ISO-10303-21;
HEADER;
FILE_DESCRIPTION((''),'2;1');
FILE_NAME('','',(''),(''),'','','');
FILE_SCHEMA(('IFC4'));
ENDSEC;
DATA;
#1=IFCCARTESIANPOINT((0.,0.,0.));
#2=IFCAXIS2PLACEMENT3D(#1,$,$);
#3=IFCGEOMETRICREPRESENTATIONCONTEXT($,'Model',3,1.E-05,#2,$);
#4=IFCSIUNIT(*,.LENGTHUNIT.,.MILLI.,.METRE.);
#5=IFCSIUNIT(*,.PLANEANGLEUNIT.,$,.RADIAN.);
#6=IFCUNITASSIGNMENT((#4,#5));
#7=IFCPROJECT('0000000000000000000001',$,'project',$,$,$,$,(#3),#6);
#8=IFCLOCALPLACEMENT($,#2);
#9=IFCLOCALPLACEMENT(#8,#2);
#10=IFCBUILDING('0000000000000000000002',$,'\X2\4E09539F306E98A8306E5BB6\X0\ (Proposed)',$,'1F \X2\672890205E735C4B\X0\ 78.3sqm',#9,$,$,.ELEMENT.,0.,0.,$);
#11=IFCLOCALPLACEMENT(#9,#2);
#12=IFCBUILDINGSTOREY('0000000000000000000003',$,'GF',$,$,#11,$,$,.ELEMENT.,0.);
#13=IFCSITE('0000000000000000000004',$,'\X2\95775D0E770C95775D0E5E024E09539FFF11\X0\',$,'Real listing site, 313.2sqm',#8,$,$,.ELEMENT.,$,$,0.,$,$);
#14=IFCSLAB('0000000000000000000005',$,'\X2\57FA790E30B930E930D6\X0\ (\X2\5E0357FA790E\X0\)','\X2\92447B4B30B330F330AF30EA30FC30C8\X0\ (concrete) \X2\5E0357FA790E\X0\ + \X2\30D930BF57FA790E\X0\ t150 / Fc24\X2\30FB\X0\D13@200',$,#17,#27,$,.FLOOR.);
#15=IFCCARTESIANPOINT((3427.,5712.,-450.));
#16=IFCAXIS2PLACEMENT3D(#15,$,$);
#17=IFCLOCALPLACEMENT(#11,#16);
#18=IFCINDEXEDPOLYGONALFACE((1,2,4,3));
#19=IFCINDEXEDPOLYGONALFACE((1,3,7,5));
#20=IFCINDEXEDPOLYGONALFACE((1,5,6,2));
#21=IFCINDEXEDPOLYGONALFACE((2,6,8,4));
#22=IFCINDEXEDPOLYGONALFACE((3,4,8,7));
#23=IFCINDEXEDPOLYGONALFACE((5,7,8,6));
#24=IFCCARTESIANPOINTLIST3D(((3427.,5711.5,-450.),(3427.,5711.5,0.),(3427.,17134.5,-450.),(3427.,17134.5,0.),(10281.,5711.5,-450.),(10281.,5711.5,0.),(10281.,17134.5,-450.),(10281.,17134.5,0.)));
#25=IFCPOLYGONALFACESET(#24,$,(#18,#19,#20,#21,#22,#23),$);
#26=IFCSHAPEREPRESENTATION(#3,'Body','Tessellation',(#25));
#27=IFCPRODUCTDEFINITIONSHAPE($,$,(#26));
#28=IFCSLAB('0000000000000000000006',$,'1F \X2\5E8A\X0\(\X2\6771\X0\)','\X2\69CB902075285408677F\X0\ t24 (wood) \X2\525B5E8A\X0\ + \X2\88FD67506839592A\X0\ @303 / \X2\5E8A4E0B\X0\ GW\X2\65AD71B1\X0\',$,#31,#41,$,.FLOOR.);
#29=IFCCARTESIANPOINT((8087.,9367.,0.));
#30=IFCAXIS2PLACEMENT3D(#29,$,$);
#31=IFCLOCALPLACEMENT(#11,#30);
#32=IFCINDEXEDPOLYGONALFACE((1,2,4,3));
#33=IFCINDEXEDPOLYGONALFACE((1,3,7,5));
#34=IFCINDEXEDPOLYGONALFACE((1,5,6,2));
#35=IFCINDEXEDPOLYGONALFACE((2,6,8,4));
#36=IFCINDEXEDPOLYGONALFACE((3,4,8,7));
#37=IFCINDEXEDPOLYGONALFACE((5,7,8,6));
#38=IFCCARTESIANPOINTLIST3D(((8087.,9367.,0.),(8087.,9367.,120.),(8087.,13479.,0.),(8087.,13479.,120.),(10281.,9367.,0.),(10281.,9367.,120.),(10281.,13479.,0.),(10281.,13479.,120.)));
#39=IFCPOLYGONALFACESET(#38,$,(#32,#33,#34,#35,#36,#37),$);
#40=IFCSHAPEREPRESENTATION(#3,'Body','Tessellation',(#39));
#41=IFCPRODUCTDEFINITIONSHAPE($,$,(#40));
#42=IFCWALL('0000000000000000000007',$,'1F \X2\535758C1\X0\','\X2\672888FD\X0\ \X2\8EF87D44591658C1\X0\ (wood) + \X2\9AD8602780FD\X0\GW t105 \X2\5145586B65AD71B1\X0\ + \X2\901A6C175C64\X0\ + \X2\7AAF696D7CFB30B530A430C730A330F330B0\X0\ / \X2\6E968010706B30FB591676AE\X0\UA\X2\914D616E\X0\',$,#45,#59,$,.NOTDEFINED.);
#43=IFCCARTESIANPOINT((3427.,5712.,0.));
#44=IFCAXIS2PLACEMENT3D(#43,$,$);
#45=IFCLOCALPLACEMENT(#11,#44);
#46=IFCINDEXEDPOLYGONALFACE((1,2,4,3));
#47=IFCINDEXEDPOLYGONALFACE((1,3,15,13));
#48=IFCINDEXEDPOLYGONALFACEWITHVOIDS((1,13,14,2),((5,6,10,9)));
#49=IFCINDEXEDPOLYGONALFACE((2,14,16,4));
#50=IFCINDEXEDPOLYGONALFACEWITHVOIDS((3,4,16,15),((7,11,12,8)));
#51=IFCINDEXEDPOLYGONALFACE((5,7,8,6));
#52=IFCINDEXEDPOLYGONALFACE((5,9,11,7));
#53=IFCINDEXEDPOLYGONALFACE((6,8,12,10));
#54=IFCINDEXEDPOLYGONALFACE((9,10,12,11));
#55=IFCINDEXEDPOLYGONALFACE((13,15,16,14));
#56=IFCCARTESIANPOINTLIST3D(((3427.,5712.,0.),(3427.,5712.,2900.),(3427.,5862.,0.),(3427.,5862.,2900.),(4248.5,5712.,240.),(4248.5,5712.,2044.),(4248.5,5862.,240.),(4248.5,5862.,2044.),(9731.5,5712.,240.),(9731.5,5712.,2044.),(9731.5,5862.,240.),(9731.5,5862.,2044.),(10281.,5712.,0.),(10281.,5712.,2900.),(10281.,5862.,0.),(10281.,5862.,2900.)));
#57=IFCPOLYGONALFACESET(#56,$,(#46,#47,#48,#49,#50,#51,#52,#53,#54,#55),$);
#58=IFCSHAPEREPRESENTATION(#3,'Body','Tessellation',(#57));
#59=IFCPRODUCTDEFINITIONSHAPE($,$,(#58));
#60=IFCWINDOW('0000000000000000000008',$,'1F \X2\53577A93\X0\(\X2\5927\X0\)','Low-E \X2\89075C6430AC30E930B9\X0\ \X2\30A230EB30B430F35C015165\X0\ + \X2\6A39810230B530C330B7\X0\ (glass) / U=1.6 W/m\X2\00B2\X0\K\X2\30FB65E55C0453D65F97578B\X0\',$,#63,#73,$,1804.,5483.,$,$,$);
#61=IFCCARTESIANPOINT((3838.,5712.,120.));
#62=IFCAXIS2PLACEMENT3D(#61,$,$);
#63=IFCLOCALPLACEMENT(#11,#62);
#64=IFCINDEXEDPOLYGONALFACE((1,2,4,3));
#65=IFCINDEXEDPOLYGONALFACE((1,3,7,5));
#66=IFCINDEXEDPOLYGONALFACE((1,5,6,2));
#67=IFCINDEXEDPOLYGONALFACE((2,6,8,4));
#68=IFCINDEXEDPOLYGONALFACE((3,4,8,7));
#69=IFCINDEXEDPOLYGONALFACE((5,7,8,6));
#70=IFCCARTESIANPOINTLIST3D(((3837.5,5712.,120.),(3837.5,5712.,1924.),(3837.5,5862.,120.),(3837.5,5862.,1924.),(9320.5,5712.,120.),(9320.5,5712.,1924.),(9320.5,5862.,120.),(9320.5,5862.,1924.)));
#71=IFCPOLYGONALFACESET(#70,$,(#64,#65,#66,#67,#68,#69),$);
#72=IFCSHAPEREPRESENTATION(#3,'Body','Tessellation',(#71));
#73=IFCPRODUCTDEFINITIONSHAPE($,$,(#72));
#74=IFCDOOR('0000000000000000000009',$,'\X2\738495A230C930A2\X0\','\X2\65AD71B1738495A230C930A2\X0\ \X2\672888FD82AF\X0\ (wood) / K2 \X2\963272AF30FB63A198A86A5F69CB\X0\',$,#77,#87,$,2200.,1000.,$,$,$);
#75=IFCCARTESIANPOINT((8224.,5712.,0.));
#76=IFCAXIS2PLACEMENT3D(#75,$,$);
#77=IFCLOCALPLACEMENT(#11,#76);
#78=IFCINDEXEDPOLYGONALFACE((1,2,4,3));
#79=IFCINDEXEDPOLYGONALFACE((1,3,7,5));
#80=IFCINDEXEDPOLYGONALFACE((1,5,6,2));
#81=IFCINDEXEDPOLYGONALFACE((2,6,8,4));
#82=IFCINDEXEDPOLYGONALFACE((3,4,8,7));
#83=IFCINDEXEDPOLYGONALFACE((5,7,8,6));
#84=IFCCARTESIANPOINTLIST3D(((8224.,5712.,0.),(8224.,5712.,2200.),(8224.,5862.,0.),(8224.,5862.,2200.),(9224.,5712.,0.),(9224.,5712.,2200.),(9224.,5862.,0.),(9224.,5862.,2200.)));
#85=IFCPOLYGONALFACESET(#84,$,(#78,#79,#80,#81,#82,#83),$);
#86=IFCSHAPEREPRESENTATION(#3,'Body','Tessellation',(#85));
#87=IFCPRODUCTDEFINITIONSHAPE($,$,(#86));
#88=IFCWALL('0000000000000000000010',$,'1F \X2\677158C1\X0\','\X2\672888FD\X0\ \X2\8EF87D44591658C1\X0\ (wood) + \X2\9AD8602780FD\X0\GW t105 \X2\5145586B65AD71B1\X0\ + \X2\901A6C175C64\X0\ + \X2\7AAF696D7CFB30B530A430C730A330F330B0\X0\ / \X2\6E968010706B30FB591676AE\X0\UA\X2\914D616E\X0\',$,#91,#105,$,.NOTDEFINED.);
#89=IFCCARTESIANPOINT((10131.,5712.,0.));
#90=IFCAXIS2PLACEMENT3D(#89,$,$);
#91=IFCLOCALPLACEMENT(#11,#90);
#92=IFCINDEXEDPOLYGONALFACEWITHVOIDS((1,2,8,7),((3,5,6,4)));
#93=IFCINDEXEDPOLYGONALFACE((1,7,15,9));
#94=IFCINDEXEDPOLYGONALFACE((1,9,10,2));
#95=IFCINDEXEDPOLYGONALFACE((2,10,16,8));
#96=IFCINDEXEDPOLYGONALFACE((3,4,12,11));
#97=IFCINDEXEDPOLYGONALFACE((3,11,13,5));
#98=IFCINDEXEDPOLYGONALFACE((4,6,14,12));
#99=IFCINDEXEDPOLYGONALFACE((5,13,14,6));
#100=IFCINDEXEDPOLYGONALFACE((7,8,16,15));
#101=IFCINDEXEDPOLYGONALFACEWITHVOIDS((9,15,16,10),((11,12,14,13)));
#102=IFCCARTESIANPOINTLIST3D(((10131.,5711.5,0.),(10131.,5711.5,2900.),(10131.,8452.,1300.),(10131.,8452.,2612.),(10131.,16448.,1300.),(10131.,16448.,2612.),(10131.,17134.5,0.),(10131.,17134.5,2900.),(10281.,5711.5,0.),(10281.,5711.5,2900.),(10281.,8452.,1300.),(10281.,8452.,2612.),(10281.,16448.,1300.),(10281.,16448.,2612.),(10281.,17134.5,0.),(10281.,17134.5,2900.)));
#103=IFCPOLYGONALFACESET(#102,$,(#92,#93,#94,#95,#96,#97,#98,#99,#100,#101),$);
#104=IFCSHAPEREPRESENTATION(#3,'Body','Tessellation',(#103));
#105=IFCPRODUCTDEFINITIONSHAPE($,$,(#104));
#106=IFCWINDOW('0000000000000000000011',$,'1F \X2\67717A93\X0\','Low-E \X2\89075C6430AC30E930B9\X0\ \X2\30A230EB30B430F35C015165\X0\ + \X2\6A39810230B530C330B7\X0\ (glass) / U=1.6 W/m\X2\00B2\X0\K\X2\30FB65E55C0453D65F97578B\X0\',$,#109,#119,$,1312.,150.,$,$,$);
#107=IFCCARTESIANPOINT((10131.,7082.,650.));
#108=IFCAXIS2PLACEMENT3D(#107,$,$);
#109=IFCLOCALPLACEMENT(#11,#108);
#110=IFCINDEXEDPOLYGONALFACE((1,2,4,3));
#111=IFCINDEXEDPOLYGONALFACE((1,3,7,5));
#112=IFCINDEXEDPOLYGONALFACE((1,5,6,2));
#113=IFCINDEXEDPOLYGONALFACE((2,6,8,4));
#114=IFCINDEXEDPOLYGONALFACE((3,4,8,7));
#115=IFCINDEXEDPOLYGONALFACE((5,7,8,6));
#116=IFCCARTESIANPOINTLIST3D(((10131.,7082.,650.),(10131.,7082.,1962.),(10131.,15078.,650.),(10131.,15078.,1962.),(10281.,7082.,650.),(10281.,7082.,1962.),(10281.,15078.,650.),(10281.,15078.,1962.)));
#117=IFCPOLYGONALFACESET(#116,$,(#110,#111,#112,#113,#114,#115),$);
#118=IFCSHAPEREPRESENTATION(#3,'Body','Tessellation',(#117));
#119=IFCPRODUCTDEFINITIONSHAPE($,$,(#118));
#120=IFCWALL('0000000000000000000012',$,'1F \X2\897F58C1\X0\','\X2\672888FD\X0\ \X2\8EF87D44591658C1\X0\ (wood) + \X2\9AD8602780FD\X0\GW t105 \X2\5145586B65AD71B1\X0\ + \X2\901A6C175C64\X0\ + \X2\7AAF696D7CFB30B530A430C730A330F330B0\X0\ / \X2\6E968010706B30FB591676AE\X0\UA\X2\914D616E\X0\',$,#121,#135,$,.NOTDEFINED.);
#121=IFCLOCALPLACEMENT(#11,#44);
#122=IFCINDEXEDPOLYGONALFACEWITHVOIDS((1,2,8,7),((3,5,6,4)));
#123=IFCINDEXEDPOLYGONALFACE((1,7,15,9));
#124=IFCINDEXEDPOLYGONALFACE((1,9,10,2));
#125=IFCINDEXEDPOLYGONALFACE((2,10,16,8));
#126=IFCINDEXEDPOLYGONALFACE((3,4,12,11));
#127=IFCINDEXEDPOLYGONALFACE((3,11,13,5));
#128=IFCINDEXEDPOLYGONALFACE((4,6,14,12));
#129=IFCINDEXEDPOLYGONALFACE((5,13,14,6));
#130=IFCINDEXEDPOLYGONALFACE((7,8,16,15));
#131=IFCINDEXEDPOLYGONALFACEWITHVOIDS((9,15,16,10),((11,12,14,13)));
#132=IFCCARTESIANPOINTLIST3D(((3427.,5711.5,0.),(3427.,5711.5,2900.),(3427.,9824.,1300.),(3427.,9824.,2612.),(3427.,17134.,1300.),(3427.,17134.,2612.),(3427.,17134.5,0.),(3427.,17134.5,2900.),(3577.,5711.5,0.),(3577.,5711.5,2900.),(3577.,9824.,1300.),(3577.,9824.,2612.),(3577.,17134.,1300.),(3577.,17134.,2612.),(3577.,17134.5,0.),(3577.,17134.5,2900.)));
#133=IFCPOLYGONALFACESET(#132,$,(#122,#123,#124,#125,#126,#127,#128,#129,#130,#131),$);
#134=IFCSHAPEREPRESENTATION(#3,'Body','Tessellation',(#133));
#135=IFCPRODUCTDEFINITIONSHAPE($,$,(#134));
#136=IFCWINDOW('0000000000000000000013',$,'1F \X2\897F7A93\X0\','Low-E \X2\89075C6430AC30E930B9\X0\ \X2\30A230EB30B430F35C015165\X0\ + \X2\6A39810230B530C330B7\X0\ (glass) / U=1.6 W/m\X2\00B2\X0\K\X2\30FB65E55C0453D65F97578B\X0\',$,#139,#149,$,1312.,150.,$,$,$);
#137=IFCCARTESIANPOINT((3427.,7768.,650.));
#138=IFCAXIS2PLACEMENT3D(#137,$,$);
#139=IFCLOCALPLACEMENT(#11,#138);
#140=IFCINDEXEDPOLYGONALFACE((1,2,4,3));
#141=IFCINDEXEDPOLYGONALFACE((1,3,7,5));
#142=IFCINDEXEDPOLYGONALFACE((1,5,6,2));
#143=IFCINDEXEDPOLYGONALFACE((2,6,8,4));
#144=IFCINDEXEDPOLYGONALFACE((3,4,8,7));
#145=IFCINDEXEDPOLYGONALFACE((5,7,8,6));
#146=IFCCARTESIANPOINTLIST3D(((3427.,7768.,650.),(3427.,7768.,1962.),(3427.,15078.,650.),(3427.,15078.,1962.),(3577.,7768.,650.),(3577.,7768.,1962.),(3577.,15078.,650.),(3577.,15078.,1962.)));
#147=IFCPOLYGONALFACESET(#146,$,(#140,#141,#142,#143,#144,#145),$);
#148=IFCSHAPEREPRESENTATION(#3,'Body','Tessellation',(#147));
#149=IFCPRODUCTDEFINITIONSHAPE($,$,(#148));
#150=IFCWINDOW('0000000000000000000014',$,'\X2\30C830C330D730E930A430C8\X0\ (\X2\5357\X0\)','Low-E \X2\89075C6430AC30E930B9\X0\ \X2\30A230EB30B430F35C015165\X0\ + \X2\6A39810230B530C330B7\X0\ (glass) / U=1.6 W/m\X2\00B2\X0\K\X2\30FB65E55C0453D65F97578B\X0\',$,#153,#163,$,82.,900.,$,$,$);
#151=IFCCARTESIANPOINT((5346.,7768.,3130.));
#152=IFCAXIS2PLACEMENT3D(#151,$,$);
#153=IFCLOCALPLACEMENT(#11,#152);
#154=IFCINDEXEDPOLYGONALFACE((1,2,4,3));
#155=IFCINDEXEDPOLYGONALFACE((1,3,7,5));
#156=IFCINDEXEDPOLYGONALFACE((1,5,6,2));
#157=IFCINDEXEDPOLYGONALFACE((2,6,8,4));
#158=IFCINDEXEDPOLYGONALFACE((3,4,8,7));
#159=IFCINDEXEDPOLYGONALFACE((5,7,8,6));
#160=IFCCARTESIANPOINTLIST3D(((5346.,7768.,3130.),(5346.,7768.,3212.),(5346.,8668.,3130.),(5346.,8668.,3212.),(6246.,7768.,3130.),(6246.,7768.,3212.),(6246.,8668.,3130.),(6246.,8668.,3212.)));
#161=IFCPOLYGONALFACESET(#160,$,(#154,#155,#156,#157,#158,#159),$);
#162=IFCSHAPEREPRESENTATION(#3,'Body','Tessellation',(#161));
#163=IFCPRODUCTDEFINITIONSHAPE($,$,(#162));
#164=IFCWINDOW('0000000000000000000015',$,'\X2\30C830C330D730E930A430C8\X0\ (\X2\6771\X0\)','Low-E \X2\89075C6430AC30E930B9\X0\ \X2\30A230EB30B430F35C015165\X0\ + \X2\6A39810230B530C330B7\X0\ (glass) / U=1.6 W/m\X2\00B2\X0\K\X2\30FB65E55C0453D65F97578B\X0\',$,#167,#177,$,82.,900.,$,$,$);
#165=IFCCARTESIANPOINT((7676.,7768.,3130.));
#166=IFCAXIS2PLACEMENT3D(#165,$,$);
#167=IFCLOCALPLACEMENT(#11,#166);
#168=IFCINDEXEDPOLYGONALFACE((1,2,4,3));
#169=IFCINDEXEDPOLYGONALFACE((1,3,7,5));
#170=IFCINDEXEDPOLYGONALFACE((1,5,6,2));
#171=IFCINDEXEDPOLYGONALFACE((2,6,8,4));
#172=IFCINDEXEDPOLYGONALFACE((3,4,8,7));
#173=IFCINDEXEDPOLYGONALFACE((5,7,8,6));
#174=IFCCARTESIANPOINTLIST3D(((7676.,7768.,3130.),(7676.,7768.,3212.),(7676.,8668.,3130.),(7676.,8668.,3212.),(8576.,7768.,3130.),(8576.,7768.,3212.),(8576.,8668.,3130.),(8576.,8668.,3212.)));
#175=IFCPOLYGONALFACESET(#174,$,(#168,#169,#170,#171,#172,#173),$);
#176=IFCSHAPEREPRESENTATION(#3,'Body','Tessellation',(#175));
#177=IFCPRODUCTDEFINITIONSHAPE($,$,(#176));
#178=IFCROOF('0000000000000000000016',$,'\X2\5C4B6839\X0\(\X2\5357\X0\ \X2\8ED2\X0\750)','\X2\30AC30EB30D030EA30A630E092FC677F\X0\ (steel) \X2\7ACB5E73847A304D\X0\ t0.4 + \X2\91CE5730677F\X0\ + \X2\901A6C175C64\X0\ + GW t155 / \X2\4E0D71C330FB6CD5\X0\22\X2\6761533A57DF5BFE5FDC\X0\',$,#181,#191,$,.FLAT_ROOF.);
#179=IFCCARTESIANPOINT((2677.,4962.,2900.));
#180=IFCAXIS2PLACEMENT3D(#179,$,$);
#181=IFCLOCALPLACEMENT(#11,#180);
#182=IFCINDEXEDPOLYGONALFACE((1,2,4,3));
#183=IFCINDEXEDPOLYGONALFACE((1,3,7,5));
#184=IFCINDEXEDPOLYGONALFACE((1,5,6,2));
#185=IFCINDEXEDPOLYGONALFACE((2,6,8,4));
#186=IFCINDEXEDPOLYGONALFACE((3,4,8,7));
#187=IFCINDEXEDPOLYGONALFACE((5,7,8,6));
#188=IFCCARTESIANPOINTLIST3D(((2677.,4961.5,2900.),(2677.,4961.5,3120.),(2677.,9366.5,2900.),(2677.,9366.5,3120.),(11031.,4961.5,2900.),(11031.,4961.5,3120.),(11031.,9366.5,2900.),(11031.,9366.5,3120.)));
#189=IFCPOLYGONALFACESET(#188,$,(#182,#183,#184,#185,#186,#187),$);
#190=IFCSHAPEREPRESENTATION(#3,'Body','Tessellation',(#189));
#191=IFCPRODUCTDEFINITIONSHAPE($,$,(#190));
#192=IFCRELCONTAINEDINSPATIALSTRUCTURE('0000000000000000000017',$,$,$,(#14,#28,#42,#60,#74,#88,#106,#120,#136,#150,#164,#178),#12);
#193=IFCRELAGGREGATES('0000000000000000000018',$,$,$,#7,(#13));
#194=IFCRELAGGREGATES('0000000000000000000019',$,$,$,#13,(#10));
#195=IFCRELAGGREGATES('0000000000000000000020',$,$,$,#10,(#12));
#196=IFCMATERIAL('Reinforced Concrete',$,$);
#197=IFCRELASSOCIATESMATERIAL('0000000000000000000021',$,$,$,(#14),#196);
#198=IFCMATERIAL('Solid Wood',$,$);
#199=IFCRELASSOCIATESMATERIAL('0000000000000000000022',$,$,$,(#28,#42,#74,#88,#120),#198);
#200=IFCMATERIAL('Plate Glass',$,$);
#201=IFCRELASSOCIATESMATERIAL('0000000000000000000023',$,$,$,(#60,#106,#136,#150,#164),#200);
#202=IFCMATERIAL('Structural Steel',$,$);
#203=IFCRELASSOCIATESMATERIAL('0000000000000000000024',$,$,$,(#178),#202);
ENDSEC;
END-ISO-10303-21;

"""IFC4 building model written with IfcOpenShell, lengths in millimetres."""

from ifc_helpers import new_model, si_unit, frame, frame_2d, origin, place, context, project, spatial, rectangle, extrude, material, element, fill, save


model = new_model("IFC4")

# Units and contexts
model_context = context("Model", 3, precision=1e-05, world=origin())
ifc_project = project(units=[si_unit("LENGTHUNIT", "METRE", prefix="MILLI"), si_unit("PLANEANGLEUNIT", "RADIAN")], contexts=[model_context])

# Site, building, storey
site_placement = place(None, origin())
site = spatial("IfcSite", under=ifc_project, at=site_placement, Name="長崎県長崎市三原１", ObjectType="Real listing site, 313.2sqm", CompositionType="ELEMENT", RefElevation=0.0)
building_placement = place(site_placement, origin())
building = spatial("IfcBuilding", under=site, at=building_placement, Name="三原の風の家 (Proposed)", ObjectType="1F 木造平屋 78.3sqm", CompositionType="ELEMENT", ElevationOfRefHeight=0.0, ElevationOfTerrain=0.0)
storey_placement = place(building_placement, origin())
storey = spatial("IfcBuildingStorey", under=building, at=storey_placement, Name="GF", CompositionType="ELEMENT", Elevation=0.0)

# Slabs
ifc_material_1 = material(Name="Reinforced Concrete")
slab_1_placement = place(storey_placement, frame((3427.0, 5712.0, -450.0)))
element("IfcSlab", 1, at=slab_1_placement, inside=storey, material=ifc_material_1, Name="基礎スラブ (布基礎)", Description="鉄筋コンクリート (concrete) 布基礎 + ベタ基礎 t150 / Fc24・D13@200", PredefinedType="FLOOR", context=model_context, shape_type="SweptSolid", body=[
    extrude(rectangle(XDim=6854.0, YDim=11423.0, at=frame_2d((3427.0, 5711.0))), frame((3427.0, 5712.0, -450.0)), (0.0, 0.0, 1.0), 450.0),
])
ifc_material_2 = material(Name="Solid Wood")
slab_2_placement = place(storey_placement, frame((8087.0, 9367.0, 0.0)))
element("IfcSlab", 2, at=slab_2_placement, inside=storey, material=ifc_material_2, Name="1F 床(東)", Description="構造用合板 t24 (wood) 剛床 + 製材根太 @303 / 床下 GW断熱", PredefinedType="FLOOR", context=model_context, shape_type="SweptSolid", body=[
    extrude(rectangle(XDim=2194.0, YDim=4112.0, at=frame_2d((1097.0, 2056.0))), frame((8087.0, 9367.0, 0.0)), (0.0, 0.0, 1.0), 120.0),
])

# Wall, openings, window, door
wall_1_placement = place(storey_placement, frame((3427.0, 5712.0, 0.0)))
wall_1 = element("IfcWall", 3, at=wall_1_placement, inside=storey, material=ifc_material_2, Name="1F 南壁", Description="木製 軸組外壁 (wood) + 高性能GW t105 充填断熱 + 通気層 + 窯業系サイディング / 準耐火・外皮UA配慮", PredefinedType="NOTDEFINED", context=model_context, shape_type="SweptSolid", body=[
    extrude(rectangle(XDim=6854.0, YDim=150.0, at=frame_2d((3427.0, 75.0))), frame((3427.0, 5712.0, 0.0)), (0.0, 0.0, 1.0), 2900.0),
])
opening_1_placement = place(storey_placement, frame((3838.0, 5712.0, 120.0)))
opening_1 = element("IfcOpeningElement", 4, at=opening_1_placement, cuts=wall_1, PredefinedType="NOTDEFINED", context=model_context, shape_type="SweptSolid", body=[
    extrude(rectangle(XDim=5483.0, YDim=150.0, at=frame_2d((2741.0, 75.0))), frame((3838.0, 5712.0, 120.0)), (0.0, 0.0, 1.0), 1804.0),
])
opening_2_placement = place(storey_placement, frame((8224.0, 5712.0, 0.0)))
opening_2 = element("IfcOpeningElement", 5, at=opening_2_placement, cuts=wall_1, PredefinedType="NOTDEFINED", context=model_context, shape_type="SweptSolid", body=[
    extrude(rectangle(XDim=1000.0, YDim=150.0, at=frame_2d((500.0, 75.0))), frame((8224.0, 5712.0, 0.0)), (0.0, 0.0, 1.0), 2200.0),
])
ifc_material_3 = material(Name="Plate Glass")
window_1_placement = place(storey_placement, frame((3838.0, 5712.0, 120.0)))
window_1 = element("IfcWindow", 6, at=window_1_placement, inside=storey, material=ifc_material_3, Name="1F 南窓(大)", Description="Low-E 複層ガラス アルゴン封入 + 樹脂サッシ (glass) / U=1.6 W/m²K・日射取得型", OverallHeight=1804.0, OverallWidth=5483.0, context=model_context, shape_type="SweptSolid", body=[
    extrude(rectangle(XDim=5483.0, YDim=150.0, at=frame_2d((2741.0, 75.0))), frame((3838.0, 5712.0, 120.0)), (0.0, 0.0, 1.0), 1804.0),
])
fill(opening_1, window_1)
door_placement = place(storey_placement, frame((8224.0, 5712.0, 0.0)))
door = element("IfcDoor", 7, at=door_placement, inside=storey, material=ifc_material_2, Name="玄関ドア", Description="断熱玄関ドア 木製芯 (wood) / K2 防犯・採風機構", OverallHeight=2200.0, OverallWidth=1000.0, context=model_context, shape_type="SweptSolid", body=[
    extrude(rectangle(XDim=1000.0, YDim=150.0, at=frame_2d((500.0, 75.0))), frame((8224.0, 5712.0, 0.0)), (0.0, 0.0, 1.0), 2200.0),
])
fill(opening_2, door)

# Walls, openings, windows
wall_2_placement = place(storey_placement, frame((10131.0, 5712.0, 0.0)))
wall_2 = element("IfcWall", 8, at=wall_2_placement, inside=storey, material=ifc_material_2, Name="1F 東壁", Description="木製 軸組外壁 (wood) + 高性能GW t105 充填断熱 + 通気層 + 窯業系サイディング / 準耐火・外皮UA配慮", PredefinedType="NOTDEFINED", context=model_context, shape_type="SweptSolid", body=[
    extrude(rectangle(XDim=150.0, YDim=11423.0, at=frame_2d((75.0, 5711.0))), frame((10131.0, 5712.0, 0.0)), (0.0, 0.0, 1.0), 2900.0),
])
opening_3_placement = place(storey_placement, frame((10131.0, 7082.0, 650.0)))
opening_3 = element("IfcOpeningElement", 9, at=opening_3_placement, cuts=wall_2, PredefinedType="NOTDEFINED", context=model_context, shape_type="SweptSolid", body=[
    extrude(rectangle(XDim=150.0, YDim=7996.0, at=frame_2d((75.0, 3998.0))), frame((10131.0, 7082.0, 650.0)), (0.0, 0.0, 1.0), 1312.0),
])
window_2_placement = place(storey_placement, frame((10131.0, 7082.0, 650.0)))
window_2 = element("IfcWindow", 10, at=window_2_placement, inside=storey, material=ifc_material_3, Name="1F 東窓", Description="Low-E 複層ガラス アルゴン封入 + 樹脂サッシ (glass) / U=1.6 W/m²K・日射取得型", OverallHeight=1312.0, OverallWidth=150.0, context=model_context, shape_type="SweptSolid", body=[
    extrude(rectangle(XDim=150.0, YDim=7996.0, at=frame_2d((75.0, 3998.0))), frame((10131.0, 7082.0, 650.0)), (0.0, 0.0, 1.0), 1312.0),
])
fill(opening_3, window_2)
wall_3_placement = place(storey_placement, frame((3427.0, 5712.0, 0.0)))
wall_3 = element("IfcWall", 11, at=wall_3_placement, inside=storey, material=ifc_material_2, Name="1F 西壁", Description="木製 軸組外壁 (wood) + 高性能GW t105 充填断熱 + 通気層 + 窯業系サイディング / 準耐火・外皮UA配慮", PredefinedType="NOTDEFINED", context=model_context, shape_type="SweptSolid", body=[
    extrude(rectangle(XDim=150.0, YDim=11423.0, at=frame_2d((75.0, 5711.0))), frame((3427.0, 5712.0, 0.0)), (0.0, 0.0, 1.0), 2900.0),
])
opening_4_placement = place(storey_placement, frame((3427.0, 7768.0, 650.0)))
opening_4 = element("IfcOpeningElement", 12, at=opening_4_placement, cuts=wall_3, PredefinedType="NOTDEFINED", context=model_context, shape_type="SweptSolid", body=[
    extrude(rectangle(XDim=150.0, YDim=7310.0, at=frame_2d((75.0, 3655.0))), frame((3427.0, 7768.0, 650.0)), (0.0, 0.0, 1.0), 1312.0),
])
window_3_placement = place(storey_placement, frame((3427.0, 7768.0, 650.0)))
window_3 = element("IfcWindow", 13, at=window_3_placement, inside=storey, material=ifc_material_3, Name="1F 西窓", Description="Low-E 複層ガラス アルゴン封入 + 樹脂サッシ (glass) / U=1.6 W/m²K・日射取得型", OverallHeight=1312.0, OverallWidth=150.0, context=model_context, shape_type="SweptSolid", body=[
    extrude(rectangle(XDim=150.0, YDim=7310.0, at=frame_2d((75.0, 3655.0))), frame((3427.0, 7768.0, 650.0)), (0.0, 0.0, 1.0), 1312.0),
])
fill(opening_4, window_3)

# Windows
window_4_placement = place(storey_placement, frame((5346.0, 7768.0, 3130.0)))
element("IfcWindow", 14, at=window_4_placement, inside=storey, material=ifc_material_3, Name="トップライト (南)", Description="Low-E 複層ガラス アルゴン封入 + 樹脂サッシ (glass) / U=1.6 W/m²K・日射取得型", OverallHeight=82.0, OverallWidth=900.0, context=model_context, shape_type="SweptSolid", body=[
    extrude(rectangle(XDim=900.0, YDim=900.0, at=frame_2d((450.0, 450.0))), frame((5346.0, 7768.0, 3130.0)), (0.0, 0.0, 1.0), 82.0),
])
window_5_placement = place(storey_placement, frame((7676.0, 7768.0, 3130.0)))
element("IfcWindow", 15, at=window_5_placement, inside=storey, material=ifc_material_3, Name="トップライト (東)", Description="Low-E 複層ガラス アルゴン封入 + 樹脂サッシ (glass) / U=1.6 W/m²K・日射取得型", OverallHeight=82.0, OverallWidth=900.0, context=model_context, shape_type="SweptSolid", body=[
    extrude(rectangle(XDim=900.0, YDim=900.0, at=frame_2d((450.0, 450.0))), frame((7676.0, 7768.0, 3130.0)), (0.0, 0.0, 1.0), 82.0),
])

# Roof
ifc_material_4 = material(Name="Structural Steel")
roof_placement = place(storey_placement, frame((2677.0, 4962.0, 2900.0)))
element("IfcRoof", 16, at=roof_placement, inside=storey, material=ifc_material_4, Name="屋根(南 軒750)", Description="ガルバリウム鋼板 (steel) 立平葺き t0.4 + 野地板 + 通気層 + GW t155 / 不燃・法22条区域対応", PredefinedType="FLAT_ROOF", context=model_context, shape_type="SweptSolid", body=[
    extrude(rectangle(XDim=8354.0, YDim=4405.0, at=frame_2d((4177.0, 2202.0))), frame((2677.0, 4962.0, 2900.0)), (0.0, 0.0, 1.0), 220.0),
])

save(model, "model.ifc")
